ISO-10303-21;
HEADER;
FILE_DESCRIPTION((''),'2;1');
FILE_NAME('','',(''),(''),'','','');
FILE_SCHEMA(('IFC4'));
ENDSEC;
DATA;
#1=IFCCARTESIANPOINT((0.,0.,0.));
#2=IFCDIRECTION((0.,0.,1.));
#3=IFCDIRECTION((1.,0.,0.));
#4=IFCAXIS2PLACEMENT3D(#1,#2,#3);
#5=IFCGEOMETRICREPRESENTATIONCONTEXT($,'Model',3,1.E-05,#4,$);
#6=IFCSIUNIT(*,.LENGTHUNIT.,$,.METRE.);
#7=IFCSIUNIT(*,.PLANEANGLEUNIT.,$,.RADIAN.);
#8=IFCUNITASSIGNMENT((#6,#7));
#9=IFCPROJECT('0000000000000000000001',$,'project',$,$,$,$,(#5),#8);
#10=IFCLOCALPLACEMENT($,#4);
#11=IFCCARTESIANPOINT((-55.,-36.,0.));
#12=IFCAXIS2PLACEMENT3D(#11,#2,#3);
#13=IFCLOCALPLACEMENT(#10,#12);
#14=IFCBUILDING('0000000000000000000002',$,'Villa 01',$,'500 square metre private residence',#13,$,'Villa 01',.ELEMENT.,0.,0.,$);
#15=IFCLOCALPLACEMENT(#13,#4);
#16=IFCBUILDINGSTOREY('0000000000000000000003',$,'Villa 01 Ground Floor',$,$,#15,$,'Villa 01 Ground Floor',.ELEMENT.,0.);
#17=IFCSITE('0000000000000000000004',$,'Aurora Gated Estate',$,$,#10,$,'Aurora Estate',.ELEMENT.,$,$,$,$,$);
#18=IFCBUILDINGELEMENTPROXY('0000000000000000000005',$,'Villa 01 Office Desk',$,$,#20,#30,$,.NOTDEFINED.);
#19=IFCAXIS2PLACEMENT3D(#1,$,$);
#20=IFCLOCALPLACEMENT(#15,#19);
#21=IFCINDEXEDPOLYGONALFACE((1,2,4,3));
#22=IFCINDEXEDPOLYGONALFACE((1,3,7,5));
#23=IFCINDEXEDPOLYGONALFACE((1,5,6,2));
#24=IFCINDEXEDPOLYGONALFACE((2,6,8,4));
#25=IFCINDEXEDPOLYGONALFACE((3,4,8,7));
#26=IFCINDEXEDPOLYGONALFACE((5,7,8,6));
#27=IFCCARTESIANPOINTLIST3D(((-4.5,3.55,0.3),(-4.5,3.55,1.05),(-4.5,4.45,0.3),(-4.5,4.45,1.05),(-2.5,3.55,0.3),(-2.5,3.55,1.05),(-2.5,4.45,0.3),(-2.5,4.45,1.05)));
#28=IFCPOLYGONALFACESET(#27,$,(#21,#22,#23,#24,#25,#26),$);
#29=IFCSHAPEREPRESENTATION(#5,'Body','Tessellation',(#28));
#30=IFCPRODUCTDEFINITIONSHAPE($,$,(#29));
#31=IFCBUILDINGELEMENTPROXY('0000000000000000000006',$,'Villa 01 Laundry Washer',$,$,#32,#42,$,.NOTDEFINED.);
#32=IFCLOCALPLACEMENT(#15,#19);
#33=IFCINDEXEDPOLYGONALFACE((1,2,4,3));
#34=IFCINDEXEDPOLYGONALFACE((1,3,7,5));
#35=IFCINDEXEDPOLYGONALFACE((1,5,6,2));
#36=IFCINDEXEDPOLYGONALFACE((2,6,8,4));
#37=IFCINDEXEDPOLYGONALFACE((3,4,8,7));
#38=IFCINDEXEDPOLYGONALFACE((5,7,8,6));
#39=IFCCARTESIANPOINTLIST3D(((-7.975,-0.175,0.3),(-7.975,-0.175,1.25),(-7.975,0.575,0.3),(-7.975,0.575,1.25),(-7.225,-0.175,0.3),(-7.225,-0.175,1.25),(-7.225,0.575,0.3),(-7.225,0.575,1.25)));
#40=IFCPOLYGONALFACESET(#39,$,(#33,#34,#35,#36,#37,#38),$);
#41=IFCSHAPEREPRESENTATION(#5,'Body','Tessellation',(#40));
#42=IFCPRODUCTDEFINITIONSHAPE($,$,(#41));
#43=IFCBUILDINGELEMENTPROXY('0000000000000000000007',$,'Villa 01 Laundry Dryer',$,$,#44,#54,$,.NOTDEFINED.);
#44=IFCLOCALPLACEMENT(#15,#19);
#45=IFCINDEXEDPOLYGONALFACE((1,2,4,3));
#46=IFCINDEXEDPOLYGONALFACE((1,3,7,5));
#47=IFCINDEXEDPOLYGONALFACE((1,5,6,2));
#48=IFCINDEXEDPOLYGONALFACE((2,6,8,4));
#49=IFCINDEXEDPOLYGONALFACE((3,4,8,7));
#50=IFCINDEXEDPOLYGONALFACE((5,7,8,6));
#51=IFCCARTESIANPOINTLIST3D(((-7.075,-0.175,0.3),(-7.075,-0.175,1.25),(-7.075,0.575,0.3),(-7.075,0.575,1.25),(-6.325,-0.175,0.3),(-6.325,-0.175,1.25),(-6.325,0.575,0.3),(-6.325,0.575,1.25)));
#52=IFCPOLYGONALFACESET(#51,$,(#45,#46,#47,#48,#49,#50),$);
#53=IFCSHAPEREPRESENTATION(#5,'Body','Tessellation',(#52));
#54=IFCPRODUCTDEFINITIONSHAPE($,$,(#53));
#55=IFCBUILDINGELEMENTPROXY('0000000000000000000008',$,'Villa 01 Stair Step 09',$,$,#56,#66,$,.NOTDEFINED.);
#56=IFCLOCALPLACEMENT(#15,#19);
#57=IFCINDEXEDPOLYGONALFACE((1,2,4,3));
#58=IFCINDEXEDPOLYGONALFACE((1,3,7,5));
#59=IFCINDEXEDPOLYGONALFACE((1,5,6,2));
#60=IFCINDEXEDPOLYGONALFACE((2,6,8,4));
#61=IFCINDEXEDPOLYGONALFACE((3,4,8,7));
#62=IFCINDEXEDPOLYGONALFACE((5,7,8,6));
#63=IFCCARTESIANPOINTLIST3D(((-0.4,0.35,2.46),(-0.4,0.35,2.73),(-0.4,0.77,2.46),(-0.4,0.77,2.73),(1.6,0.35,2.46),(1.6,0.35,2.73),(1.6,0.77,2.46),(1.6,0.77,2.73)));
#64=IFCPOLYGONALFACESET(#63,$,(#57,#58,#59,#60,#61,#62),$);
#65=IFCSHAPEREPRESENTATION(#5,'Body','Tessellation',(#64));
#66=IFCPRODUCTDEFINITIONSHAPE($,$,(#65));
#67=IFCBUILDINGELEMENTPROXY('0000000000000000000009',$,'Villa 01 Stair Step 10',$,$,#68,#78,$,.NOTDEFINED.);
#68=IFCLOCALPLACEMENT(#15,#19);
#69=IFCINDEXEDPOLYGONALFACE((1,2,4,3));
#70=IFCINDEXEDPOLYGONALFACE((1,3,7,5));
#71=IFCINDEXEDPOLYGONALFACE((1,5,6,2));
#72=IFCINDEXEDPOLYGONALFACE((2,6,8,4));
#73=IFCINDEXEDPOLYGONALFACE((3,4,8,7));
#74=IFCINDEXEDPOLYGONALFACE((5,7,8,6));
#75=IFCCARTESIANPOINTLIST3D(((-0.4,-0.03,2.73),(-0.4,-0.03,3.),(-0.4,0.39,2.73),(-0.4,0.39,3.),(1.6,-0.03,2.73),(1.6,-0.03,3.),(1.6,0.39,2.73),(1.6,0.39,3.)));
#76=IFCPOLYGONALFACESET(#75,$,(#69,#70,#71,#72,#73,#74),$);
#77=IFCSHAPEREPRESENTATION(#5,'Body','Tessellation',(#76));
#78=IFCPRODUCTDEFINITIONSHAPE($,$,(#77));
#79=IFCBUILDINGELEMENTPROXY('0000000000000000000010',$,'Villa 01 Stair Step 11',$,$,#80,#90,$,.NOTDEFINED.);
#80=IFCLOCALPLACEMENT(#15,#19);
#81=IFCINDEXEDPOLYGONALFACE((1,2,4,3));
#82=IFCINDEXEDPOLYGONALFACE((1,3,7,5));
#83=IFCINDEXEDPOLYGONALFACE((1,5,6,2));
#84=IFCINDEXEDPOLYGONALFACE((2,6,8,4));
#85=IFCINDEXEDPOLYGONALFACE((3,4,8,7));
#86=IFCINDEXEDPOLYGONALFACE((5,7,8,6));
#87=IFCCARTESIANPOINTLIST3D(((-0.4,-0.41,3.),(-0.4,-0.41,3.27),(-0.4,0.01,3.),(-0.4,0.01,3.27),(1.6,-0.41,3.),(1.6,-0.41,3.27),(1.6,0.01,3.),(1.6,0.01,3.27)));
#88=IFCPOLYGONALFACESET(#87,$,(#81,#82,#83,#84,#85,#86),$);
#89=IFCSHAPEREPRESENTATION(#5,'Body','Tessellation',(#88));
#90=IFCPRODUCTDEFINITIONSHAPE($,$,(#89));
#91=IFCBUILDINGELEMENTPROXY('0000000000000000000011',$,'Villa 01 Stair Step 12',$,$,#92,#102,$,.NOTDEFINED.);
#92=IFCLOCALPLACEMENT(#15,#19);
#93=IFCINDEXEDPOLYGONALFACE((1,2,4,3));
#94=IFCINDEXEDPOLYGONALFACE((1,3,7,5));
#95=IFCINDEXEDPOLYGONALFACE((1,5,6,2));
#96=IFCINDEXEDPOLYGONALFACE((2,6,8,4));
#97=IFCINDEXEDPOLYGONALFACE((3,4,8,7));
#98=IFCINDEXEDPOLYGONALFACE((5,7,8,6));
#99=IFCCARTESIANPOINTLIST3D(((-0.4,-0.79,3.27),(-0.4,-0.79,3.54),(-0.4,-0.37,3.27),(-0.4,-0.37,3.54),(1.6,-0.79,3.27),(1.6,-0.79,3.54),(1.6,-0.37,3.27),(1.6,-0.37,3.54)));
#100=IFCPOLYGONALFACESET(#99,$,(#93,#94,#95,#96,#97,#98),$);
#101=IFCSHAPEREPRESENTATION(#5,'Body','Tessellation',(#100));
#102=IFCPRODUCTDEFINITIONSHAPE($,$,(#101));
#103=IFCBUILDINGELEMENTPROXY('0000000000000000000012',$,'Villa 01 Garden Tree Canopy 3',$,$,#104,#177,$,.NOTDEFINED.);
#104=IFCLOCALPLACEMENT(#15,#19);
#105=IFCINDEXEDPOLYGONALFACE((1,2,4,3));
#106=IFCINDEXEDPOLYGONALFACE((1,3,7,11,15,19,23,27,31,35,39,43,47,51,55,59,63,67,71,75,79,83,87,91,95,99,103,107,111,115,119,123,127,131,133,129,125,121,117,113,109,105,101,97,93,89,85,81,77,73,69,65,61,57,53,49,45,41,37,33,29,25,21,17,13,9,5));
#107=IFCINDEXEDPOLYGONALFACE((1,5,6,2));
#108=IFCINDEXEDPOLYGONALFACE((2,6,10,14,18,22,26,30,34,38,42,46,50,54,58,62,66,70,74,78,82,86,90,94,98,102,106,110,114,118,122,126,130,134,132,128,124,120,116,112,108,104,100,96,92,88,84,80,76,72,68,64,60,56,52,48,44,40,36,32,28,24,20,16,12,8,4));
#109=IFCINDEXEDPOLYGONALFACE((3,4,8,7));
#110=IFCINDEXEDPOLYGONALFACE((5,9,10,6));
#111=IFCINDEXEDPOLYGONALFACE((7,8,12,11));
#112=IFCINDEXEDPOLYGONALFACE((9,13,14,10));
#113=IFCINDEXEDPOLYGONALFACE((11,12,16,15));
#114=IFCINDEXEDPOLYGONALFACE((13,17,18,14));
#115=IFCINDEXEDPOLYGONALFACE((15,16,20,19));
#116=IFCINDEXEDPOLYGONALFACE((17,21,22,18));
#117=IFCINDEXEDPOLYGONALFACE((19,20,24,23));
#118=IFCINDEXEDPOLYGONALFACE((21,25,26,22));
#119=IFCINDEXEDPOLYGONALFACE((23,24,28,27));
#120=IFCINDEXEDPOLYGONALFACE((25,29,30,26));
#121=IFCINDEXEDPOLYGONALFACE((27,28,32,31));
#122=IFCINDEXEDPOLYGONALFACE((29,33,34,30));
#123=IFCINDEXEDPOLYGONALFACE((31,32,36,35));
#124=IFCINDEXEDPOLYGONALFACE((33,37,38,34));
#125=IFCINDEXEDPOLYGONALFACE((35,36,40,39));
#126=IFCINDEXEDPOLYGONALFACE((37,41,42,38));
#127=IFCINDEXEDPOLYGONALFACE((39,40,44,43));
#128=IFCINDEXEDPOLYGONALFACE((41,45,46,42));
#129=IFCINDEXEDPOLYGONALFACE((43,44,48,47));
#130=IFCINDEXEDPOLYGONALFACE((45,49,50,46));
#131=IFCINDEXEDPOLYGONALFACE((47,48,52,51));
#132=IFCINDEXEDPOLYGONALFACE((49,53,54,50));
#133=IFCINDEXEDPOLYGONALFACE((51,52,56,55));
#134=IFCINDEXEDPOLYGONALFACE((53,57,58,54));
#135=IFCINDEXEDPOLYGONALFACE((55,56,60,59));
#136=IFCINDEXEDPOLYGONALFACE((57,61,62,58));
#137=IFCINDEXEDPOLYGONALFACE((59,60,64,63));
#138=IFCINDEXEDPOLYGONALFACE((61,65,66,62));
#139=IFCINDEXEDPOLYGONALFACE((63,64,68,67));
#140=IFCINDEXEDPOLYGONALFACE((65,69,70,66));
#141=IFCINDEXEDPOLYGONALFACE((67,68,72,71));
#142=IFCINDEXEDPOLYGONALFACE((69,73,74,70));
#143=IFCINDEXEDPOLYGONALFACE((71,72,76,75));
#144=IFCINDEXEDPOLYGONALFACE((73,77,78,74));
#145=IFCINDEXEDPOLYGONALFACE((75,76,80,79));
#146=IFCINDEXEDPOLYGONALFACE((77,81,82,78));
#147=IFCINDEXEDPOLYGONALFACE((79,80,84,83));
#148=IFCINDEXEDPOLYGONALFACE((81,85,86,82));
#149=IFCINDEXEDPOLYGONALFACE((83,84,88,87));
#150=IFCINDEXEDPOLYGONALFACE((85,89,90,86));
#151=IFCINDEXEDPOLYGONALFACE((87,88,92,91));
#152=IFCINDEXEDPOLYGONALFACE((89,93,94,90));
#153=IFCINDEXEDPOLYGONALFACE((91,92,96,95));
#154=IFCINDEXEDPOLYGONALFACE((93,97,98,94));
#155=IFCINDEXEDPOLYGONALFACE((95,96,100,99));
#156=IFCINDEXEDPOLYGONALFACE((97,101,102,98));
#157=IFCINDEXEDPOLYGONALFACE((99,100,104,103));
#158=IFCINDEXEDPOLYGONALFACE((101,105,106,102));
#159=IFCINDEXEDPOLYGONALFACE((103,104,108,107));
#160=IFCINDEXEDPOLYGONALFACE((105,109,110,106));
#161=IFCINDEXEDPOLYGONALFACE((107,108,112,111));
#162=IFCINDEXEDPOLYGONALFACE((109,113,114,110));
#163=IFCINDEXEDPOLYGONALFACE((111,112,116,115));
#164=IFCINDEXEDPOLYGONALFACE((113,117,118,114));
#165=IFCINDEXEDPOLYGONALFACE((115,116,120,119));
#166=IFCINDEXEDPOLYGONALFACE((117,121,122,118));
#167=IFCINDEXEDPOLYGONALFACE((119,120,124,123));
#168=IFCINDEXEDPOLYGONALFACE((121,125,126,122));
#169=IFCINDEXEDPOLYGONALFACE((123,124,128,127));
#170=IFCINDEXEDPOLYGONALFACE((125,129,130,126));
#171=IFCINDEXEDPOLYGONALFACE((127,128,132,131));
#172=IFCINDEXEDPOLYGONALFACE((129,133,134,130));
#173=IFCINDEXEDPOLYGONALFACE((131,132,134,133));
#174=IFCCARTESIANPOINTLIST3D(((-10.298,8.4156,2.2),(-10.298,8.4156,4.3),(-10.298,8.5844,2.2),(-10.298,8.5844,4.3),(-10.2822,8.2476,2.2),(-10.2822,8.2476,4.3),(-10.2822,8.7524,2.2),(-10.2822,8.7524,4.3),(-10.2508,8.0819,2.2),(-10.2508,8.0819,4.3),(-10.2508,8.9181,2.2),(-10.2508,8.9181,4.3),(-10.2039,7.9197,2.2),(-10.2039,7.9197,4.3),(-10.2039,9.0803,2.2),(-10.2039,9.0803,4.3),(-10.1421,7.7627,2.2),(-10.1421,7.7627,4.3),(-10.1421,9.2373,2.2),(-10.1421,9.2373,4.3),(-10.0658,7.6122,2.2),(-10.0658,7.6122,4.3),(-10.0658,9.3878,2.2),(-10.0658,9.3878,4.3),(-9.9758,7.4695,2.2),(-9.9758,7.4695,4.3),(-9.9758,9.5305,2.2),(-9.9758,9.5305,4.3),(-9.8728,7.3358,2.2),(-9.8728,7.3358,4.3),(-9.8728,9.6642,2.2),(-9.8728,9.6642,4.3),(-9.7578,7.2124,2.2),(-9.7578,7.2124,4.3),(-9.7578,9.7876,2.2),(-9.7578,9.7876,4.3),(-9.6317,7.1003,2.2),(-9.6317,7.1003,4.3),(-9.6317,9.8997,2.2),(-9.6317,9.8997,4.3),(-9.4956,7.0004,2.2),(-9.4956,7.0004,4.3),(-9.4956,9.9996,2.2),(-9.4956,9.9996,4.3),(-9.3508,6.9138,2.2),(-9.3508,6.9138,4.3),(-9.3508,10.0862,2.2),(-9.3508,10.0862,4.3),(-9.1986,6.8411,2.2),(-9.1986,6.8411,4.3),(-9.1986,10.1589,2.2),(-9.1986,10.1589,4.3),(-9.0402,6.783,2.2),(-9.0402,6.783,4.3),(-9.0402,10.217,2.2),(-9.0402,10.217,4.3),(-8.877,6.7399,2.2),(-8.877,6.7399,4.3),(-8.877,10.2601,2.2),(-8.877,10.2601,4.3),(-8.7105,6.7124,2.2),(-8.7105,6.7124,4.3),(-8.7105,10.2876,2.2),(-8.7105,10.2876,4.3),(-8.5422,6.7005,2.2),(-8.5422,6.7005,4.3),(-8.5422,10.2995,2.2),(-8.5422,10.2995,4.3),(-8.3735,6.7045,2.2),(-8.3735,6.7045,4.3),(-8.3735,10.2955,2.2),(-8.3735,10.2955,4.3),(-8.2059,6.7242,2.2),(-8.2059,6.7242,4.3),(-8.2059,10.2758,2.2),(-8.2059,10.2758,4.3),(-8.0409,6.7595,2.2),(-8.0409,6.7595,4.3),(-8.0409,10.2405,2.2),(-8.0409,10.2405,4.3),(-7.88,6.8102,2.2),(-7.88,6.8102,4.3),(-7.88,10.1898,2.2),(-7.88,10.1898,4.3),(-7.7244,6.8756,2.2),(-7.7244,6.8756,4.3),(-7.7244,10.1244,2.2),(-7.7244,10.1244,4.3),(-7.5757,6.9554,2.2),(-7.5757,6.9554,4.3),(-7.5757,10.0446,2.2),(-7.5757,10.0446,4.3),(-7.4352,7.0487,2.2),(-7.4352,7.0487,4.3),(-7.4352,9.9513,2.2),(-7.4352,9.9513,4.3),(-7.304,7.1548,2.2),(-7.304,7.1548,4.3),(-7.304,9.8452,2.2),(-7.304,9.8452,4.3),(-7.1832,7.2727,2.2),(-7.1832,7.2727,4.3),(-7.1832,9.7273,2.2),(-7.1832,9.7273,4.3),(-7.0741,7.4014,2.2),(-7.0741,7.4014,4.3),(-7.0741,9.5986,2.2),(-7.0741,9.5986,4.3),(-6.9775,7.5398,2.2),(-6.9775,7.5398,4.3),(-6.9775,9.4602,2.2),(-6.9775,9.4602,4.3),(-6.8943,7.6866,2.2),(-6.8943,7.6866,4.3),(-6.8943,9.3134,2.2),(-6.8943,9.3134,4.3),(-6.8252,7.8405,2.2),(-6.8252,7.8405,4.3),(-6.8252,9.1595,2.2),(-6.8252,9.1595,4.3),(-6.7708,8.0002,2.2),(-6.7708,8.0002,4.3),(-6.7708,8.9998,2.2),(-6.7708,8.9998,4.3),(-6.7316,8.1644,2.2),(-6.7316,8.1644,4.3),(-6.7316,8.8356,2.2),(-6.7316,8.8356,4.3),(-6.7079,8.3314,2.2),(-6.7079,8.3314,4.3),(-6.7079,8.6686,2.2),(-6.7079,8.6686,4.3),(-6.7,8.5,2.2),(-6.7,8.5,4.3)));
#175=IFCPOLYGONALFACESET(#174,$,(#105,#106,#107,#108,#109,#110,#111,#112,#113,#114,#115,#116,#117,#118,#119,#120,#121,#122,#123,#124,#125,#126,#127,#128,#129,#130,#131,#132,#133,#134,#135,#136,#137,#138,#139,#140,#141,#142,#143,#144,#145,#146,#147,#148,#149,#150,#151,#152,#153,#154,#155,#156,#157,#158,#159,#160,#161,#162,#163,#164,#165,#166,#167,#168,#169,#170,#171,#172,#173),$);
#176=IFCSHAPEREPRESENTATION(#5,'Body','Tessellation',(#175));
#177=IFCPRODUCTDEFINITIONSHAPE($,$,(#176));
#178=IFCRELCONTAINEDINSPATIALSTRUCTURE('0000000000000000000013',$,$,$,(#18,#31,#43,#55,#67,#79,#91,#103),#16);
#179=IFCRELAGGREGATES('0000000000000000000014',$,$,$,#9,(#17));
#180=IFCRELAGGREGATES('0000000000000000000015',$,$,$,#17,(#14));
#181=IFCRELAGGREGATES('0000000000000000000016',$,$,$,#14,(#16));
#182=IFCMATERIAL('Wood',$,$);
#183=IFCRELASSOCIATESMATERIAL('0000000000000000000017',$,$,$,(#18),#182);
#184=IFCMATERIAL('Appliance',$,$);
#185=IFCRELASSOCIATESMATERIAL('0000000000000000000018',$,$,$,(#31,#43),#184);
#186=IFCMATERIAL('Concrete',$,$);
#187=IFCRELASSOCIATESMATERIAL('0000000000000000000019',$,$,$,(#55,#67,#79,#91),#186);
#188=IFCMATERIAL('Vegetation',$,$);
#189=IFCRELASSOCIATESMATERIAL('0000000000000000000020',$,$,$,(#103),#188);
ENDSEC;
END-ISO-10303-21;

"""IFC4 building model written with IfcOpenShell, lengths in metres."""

from ifc_helpers import new_model, si_unit, frame, origin_with_axes, origin_2d_with_axis, place, context, project, spatial, rectangle, circle, extrude, material, element, save


model = new_model("IFC4")

# Units and contexts
model_context = context("Model", 3, precision=1e-05, world=origin_with_axes())
ifc_project = project(units=[si_unit("LENGTHUNIT", "METRE"), si_unit("PLANEANGLEUNIT", "RADIAN")], contexts=[model_context])

# Site, building, storey
site_placement = place(None, origin_with_axes())
site = spatial("IfcSite", under=ifc_project, at=site_placement, Name="Aurora Gated Estate", LongName="Aurora Estate", CompositionType="ELEMENT")
building_placement = place(site_placement, frame((-55.0, -36.0, 0.0), z_axis=(0.0, 0.0, 1.0), x_axis=(1.0, 0.0, 0.0)))
building = spatial("IfcBuilding", under=site, at=building_placement, Name="Villa 01", ObjectType="500 square metre private residence", LongName="Villa 01", CompositionType="ELEMENT", ElevationOfRefHeight=0.0, ElevationOfTerrain=0.0)
storey_placement = place(building_placement, origin_with_axes())
storey = spatial("IfcBuildingStorey", under=building, at=storey_placement, Name="Villa 01 Ground Floor", LongName="Villa 01 Ground Floor", CompositionType="ELEMENT", Elevation=0.0)

# Shared definitions
ifc_material_1 = material(Name="Wood")

# Shared definitions
ifc_material_2 = material(Name="Concrete")

# Building element proxies
ifc_material_3 = material(Name="Appliance")
proxy_1_placement = place(storey_placement, frame((-3.5, 4.0, 0.3), z_axis=(0.0, 0.0, 1.0), x_axis=(1.0, 0.0, 0.0)))
element("IfcBuildingElementProxy", 1, at=proxy_1_placement, inside=storey, material=ifc_material_1, Name="Villa 01 Office Desk", PredefinedType="NOTDEFINED", context=model_context, shape_type="SweptSolid", body=[
    extrude(rectangle(XDim=2.0, YDim=0.9, at=origin_2d_with_axis()), origin_with_axes(), (0.0, 0.0, 1.0), 0.75),
])
for number, where, z_axis, x_axis, name in (
    (2, (-7.6, 0.2, 0.3), (0.0, 0.0, 1.0), (1.0, 0.0, 0.0), "Villa 01 Laundry Washer"),
    (3, (-6.7, 0.2, 0.3), (0.0, 0.0, 1.0), (1.0, 0.0, 0.0), "Villa 01 Laundry Dryer"),
):
    element("IfcBuildingElementProxy", number, at=place(storey_placement, frame(where, z_axis=z_axis, x_axis=x_axis)), inside=storey, material=ifc_material_3, Name=name, PredefinedType="NOTDEFINED", context=model_context, shape_type="SweptSolid", body=[
        extrude(rectangle(XDim=0.75, YDim=0.75, at=origin_2d_with_axis()), origin_with_axes(), (0.0, 0.0, 1.0), 0.95),
    ])
for number, where, z_axis, x_axis, name in (
    (4, (0.6, 0.56, 2.46), (0.0, 0.0, 1.0), (1.0, 0.0, 0.0), "Villa 01 Stair Step 09"),
    (5, (0.6, 0.18, 2.73), (0.0, 0.0, 1.0), (1.0, 0.0, 0.0), "Villa 01 Stair Step 10"),
    (6, (0.6, -0.2, 3.0), (0.0, 0.0, 1.0), (1.0, 0.0, 0.0), "Villa 01 Stair Step 11"),
    (7, (0.6, -0.58, 3.27), (0.0, 0.0, 1.0), (1.0, 0.0, 0.0), "Villa 01 Stair Step 12"),
):
    element("IfcBuildingElementProxy", number, at=place(storey_placement, frame(where, z_axis=z_axis, x_axis=x_axis)), inside=storey, material=ifc_material_2, Name=name, PredefinedType="NOTDEFINED", context=model_context, shape_type="SweptSolid", body=[
        extrude(rectangle(XDim=2.0, YDim=0.42, at=origin_2d_with_axis()), origin_with_axes(), (0.0, 0.0, 1.0), 0.27),
    ])
ifc_material_4 = material(Name="Vegetation")
proxy_2_placement = place(storey_placement, frame((-8.5, 8.5, 2.2), z_axis=(0.0, 0.0, 1.0), x_axis=(1.0, 0.0, 0.0)))
element("IfcBuildingElementProxy", 8, at=proxy_2_placement, inside=storey, material=ifc_material_4, Name="Villa 01 Garden Tree Canopy 3", PredefinedType="NOTDEFINED", context=model_context, shape_type="SweptSolid", body=[
    extrude(circle(Radius=1.8, at=origin_2d_with_axis()), origin_with_axes(), (0.0, 0.0, 1.0), 2.1),
])

save(model, "model.ifc")
